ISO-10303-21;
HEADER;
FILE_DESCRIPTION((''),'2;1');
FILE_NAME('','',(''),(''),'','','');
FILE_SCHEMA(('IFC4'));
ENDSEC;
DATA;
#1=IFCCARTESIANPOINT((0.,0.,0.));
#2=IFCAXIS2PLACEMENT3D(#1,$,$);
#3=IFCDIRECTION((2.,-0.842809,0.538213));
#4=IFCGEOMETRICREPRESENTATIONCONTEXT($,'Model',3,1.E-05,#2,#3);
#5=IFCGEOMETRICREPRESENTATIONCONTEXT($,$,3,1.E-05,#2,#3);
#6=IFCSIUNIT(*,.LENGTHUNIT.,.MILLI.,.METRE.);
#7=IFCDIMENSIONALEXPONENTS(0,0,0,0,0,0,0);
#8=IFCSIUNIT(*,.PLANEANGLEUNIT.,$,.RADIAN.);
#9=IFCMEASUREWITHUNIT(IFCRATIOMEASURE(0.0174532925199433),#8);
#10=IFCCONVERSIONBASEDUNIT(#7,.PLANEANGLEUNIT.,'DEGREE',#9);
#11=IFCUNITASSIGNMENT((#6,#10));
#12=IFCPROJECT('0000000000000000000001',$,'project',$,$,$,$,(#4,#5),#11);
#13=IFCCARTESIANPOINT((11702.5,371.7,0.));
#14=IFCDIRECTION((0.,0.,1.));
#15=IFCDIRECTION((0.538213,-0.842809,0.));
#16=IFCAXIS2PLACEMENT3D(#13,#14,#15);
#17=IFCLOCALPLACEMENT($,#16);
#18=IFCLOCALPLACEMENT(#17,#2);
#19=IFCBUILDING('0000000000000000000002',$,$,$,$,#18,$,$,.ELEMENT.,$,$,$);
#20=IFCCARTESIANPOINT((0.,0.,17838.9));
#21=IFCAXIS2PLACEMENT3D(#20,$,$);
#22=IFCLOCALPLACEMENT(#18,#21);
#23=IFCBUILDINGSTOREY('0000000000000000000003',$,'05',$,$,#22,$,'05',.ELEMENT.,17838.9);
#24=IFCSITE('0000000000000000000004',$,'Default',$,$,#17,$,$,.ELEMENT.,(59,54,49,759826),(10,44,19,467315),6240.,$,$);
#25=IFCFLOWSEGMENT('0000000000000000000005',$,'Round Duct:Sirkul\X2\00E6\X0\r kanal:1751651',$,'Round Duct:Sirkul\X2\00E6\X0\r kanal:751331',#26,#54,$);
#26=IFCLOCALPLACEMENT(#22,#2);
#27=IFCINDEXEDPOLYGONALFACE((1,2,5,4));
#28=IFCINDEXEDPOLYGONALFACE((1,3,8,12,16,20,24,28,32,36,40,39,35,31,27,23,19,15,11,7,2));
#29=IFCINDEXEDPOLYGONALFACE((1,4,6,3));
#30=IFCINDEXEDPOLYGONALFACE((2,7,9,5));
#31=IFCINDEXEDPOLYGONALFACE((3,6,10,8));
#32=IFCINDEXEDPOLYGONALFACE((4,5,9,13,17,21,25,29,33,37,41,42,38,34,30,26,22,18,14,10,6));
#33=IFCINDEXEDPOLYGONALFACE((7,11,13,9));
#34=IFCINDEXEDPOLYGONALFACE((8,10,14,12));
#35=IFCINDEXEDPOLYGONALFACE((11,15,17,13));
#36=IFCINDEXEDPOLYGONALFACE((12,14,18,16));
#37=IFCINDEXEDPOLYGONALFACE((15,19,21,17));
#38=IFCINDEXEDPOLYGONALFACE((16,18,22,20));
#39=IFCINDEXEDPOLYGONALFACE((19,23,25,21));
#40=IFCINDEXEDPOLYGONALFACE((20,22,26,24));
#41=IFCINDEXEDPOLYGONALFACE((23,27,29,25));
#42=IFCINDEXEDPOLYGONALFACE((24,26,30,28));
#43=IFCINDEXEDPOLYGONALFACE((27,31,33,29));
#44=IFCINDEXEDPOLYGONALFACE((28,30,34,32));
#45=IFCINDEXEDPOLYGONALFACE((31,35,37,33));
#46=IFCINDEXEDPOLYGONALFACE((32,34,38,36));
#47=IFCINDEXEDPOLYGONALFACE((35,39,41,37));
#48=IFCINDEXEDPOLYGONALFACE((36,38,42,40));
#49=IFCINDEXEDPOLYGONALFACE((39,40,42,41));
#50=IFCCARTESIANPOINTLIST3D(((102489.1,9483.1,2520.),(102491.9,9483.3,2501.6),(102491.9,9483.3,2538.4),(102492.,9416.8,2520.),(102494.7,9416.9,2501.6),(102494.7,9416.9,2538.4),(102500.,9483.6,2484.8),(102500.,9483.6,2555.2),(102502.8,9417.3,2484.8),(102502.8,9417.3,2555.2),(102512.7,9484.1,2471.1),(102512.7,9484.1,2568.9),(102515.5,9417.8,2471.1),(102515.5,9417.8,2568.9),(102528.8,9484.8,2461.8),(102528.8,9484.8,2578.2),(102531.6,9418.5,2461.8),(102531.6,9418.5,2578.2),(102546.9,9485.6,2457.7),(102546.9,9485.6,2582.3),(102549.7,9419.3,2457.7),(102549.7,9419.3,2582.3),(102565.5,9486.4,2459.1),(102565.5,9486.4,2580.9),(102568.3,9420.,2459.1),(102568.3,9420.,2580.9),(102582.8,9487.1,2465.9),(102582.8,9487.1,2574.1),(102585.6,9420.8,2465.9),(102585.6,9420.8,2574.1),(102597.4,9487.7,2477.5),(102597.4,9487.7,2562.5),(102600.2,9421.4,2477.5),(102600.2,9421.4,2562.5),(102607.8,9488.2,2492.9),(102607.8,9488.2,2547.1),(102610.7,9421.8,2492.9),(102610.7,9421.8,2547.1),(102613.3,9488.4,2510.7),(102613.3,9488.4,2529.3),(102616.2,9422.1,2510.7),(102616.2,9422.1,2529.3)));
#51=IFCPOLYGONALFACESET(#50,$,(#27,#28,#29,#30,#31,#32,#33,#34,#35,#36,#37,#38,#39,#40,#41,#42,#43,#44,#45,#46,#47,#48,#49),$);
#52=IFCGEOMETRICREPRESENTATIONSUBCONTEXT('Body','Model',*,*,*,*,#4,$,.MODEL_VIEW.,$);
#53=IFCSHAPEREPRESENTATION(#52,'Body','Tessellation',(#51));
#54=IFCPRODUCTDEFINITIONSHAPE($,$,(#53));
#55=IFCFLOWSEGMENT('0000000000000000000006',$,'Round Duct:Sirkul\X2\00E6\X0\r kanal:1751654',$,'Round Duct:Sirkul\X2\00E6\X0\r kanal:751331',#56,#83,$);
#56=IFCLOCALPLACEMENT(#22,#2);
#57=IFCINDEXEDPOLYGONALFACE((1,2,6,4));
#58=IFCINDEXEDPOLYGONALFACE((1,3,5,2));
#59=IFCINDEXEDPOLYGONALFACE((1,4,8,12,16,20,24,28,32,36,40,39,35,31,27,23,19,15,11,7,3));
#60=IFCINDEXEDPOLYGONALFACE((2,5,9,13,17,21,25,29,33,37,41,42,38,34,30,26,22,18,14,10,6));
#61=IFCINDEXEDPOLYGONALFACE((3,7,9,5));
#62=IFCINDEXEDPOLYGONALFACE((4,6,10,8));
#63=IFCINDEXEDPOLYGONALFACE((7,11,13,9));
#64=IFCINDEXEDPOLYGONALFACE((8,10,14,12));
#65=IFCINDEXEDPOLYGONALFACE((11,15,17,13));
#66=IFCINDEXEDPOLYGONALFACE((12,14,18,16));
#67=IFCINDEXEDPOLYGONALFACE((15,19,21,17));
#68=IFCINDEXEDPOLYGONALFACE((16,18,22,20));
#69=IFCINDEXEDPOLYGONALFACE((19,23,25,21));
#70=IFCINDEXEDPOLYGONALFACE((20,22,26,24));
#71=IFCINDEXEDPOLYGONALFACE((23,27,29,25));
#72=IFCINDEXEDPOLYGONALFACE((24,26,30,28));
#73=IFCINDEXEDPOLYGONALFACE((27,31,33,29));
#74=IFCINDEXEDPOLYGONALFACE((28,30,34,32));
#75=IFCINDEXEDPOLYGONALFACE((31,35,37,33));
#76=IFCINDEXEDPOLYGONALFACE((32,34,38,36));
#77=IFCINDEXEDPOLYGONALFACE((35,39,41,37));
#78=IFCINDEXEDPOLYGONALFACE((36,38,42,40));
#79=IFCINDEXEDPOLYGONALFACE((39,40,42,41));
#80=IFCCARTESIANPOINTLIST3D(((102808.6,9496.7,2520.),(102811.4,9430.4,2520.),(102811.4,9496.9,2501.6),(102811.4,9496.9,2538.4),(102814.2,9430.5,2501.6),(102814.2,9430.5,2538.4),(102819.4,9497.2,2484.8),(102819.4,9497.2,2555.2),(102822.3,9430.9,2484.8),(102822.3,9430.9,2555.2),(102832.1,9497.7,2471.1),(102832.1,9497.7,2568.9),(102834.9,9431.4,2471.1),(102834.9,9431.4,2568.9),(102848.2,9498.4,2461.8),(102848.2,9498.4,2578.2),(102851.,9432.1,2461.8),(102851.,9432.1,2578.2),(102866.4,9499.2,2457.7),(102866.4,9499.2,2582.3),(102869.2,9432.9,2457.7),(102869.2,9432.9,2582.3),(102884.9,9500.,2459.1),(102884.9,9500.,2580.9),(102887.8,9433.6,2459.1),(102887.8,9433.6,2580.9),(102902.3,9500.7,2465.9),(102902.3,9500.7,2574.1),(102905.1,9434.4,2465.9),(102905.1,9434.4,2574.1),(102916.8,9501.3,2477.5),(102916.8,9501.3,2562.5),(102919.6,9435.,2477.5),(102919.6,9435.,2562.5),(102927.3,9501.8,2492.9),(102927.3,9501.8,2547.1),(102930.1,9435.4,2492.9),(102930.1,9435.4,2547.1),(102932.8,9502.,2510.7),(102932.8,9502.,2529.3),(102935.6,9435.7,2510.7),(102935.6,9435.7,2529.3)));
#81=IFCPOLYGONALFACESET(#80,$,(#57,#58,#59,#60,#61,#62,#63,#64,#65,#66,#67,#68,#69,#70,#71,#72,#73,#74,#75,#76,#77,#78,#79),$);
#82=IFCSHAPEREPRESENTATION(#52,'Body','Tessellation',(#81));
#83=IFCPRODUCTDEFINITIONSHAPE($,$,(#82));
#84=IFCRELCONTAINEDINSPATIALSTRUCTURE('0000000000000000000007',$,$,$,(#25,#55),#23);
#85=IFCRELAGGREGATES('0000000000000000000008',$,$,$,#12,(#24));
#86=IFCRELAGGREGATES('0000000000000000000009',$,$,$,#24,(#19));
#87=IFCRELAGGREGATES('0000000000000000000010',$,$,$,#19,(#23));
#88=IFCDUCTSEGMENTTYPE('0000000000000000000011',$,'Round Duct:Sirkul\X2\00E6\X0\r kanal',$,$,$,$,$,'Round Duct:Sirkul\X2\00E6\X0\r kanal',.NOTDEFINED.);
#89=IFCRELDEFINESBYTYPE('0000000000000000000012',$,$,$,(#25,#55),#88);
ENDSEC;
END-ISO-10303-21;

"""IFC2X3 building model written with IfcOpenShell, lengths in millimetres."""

from ifc_helpers import new_model, entity, si_unit, converted_unit, direction, frame, frame_2d, origin, origin_2d_with_axis, place, context, subcontext, project, spatial, circle, extrude, type_object, element, save


model = new_model("IFC2X3")

# Units and contexts
model_context = context("Model", 3, precision=1e-05, world=origin(), true_north=direction((2.0, -0.842809, 0.538213)))
context_of_model = context(None, 3, precision=1e-05, world=origin(), true_north=direction((2.0, -0.842809, 0.538213)))
body_context = subcontext(model_context, "Body", "Model", "MODEL_VIEW")
ifc_project = project(units=[si_unit("LENGTHUNIT", "METRE", prefix="MILLI"), converted_unit("PLANEANGLEUNIT", "DEGREE", entity("IfcRatioMeasure", 0.0174532925199433), si_unit("PLANEANGLEUNIT", "RADIAN"), dimensions=[0, 0, 0, 0, 0, 0, 0])], contexts=[model_context, context_of_model])

# Site, building, storey
site_placement = place(None, frame((11702.5, 371.7, 0.0), z_axis=(0.0, 0.0, 1.0), x_axis=(0.538213, -0.842809, 0.0)))
site = spatial("IfcSite", under=ifc_project, at=site_placement, Name="Default", CompositionType="ELEMENT", RefLatitude=(59, 54, 49, 759826), RefLongitude=(10, 44, 19, 467315), RefElevation=6240.0)
building_placement = place(site_placement, origin())
building = spatial("IfcBuilding", under=site, at=building_placement, CompositionType="ELEMENT")
storey_placement = place(building_placement, frame((0.0, 0.0, 17838.9)))
storey = spatial("IfcBuildingStorey", under=building, at=storey_placement, Name="05", LongName="05", CompositionType="ELEMENT", Elevation=17838.9)

# Flow segments
duct_segment_type = type_object("IfcDuctSegmentType", Name="Round Duct:Sirkulær kanal", ElementType="Round Duct:Sirkulær kanal", PredefinedType="NOTDEFINED")
flow_segment_1_placement = place(storey_placement, origin())
element("IfcFlowSegment", 1, at=flow_segment_1_placement, inside=storey, type_object=duct_segment_type, Name="Round Duct:Sirkulær kanal:1751651", ObjectType="Round Duct:Sirkulær kanal:751331", context=body_context, shape_type="SweptSolid", body=[
    extrude(circle(Radius=62.5, at=frame_2d((0.0, 0.0), x_axis=(1.0, 0.0))), frame((102554.4, 9419.5, 2520.0), z_axis=(-0.042537, 0.999095, 0.0), x_axis=(-0.999095, -0.042537, 0.0)), (0.0, 0.0, 1.0), 66.4),
])
flow_segment_2_placement = place(storey_placement, origin())
element("IfcFlowSegment", 2, at=flow_segment_2_placement, inside=storey, type_object=duct_segment_type, Name="Round Duct:Sirkulær kanal:1751654", ObjectType="Round Duct:Sirkulær kanal:751331", context=body_context, shape_type="SweptSolid", body=[
    extrude(circle(Radius=62.5, at=origin_2d_with_axis()), frame((102873.9, 9433.1, 2520.0), z_axis=(-0.042537, 0.999095, 0.0), x_axis=(-0.999095, -0.042537, 0.0)), (0.0, 0.0, 1.0), 66.4),
])

save(model, "model.ifc")
